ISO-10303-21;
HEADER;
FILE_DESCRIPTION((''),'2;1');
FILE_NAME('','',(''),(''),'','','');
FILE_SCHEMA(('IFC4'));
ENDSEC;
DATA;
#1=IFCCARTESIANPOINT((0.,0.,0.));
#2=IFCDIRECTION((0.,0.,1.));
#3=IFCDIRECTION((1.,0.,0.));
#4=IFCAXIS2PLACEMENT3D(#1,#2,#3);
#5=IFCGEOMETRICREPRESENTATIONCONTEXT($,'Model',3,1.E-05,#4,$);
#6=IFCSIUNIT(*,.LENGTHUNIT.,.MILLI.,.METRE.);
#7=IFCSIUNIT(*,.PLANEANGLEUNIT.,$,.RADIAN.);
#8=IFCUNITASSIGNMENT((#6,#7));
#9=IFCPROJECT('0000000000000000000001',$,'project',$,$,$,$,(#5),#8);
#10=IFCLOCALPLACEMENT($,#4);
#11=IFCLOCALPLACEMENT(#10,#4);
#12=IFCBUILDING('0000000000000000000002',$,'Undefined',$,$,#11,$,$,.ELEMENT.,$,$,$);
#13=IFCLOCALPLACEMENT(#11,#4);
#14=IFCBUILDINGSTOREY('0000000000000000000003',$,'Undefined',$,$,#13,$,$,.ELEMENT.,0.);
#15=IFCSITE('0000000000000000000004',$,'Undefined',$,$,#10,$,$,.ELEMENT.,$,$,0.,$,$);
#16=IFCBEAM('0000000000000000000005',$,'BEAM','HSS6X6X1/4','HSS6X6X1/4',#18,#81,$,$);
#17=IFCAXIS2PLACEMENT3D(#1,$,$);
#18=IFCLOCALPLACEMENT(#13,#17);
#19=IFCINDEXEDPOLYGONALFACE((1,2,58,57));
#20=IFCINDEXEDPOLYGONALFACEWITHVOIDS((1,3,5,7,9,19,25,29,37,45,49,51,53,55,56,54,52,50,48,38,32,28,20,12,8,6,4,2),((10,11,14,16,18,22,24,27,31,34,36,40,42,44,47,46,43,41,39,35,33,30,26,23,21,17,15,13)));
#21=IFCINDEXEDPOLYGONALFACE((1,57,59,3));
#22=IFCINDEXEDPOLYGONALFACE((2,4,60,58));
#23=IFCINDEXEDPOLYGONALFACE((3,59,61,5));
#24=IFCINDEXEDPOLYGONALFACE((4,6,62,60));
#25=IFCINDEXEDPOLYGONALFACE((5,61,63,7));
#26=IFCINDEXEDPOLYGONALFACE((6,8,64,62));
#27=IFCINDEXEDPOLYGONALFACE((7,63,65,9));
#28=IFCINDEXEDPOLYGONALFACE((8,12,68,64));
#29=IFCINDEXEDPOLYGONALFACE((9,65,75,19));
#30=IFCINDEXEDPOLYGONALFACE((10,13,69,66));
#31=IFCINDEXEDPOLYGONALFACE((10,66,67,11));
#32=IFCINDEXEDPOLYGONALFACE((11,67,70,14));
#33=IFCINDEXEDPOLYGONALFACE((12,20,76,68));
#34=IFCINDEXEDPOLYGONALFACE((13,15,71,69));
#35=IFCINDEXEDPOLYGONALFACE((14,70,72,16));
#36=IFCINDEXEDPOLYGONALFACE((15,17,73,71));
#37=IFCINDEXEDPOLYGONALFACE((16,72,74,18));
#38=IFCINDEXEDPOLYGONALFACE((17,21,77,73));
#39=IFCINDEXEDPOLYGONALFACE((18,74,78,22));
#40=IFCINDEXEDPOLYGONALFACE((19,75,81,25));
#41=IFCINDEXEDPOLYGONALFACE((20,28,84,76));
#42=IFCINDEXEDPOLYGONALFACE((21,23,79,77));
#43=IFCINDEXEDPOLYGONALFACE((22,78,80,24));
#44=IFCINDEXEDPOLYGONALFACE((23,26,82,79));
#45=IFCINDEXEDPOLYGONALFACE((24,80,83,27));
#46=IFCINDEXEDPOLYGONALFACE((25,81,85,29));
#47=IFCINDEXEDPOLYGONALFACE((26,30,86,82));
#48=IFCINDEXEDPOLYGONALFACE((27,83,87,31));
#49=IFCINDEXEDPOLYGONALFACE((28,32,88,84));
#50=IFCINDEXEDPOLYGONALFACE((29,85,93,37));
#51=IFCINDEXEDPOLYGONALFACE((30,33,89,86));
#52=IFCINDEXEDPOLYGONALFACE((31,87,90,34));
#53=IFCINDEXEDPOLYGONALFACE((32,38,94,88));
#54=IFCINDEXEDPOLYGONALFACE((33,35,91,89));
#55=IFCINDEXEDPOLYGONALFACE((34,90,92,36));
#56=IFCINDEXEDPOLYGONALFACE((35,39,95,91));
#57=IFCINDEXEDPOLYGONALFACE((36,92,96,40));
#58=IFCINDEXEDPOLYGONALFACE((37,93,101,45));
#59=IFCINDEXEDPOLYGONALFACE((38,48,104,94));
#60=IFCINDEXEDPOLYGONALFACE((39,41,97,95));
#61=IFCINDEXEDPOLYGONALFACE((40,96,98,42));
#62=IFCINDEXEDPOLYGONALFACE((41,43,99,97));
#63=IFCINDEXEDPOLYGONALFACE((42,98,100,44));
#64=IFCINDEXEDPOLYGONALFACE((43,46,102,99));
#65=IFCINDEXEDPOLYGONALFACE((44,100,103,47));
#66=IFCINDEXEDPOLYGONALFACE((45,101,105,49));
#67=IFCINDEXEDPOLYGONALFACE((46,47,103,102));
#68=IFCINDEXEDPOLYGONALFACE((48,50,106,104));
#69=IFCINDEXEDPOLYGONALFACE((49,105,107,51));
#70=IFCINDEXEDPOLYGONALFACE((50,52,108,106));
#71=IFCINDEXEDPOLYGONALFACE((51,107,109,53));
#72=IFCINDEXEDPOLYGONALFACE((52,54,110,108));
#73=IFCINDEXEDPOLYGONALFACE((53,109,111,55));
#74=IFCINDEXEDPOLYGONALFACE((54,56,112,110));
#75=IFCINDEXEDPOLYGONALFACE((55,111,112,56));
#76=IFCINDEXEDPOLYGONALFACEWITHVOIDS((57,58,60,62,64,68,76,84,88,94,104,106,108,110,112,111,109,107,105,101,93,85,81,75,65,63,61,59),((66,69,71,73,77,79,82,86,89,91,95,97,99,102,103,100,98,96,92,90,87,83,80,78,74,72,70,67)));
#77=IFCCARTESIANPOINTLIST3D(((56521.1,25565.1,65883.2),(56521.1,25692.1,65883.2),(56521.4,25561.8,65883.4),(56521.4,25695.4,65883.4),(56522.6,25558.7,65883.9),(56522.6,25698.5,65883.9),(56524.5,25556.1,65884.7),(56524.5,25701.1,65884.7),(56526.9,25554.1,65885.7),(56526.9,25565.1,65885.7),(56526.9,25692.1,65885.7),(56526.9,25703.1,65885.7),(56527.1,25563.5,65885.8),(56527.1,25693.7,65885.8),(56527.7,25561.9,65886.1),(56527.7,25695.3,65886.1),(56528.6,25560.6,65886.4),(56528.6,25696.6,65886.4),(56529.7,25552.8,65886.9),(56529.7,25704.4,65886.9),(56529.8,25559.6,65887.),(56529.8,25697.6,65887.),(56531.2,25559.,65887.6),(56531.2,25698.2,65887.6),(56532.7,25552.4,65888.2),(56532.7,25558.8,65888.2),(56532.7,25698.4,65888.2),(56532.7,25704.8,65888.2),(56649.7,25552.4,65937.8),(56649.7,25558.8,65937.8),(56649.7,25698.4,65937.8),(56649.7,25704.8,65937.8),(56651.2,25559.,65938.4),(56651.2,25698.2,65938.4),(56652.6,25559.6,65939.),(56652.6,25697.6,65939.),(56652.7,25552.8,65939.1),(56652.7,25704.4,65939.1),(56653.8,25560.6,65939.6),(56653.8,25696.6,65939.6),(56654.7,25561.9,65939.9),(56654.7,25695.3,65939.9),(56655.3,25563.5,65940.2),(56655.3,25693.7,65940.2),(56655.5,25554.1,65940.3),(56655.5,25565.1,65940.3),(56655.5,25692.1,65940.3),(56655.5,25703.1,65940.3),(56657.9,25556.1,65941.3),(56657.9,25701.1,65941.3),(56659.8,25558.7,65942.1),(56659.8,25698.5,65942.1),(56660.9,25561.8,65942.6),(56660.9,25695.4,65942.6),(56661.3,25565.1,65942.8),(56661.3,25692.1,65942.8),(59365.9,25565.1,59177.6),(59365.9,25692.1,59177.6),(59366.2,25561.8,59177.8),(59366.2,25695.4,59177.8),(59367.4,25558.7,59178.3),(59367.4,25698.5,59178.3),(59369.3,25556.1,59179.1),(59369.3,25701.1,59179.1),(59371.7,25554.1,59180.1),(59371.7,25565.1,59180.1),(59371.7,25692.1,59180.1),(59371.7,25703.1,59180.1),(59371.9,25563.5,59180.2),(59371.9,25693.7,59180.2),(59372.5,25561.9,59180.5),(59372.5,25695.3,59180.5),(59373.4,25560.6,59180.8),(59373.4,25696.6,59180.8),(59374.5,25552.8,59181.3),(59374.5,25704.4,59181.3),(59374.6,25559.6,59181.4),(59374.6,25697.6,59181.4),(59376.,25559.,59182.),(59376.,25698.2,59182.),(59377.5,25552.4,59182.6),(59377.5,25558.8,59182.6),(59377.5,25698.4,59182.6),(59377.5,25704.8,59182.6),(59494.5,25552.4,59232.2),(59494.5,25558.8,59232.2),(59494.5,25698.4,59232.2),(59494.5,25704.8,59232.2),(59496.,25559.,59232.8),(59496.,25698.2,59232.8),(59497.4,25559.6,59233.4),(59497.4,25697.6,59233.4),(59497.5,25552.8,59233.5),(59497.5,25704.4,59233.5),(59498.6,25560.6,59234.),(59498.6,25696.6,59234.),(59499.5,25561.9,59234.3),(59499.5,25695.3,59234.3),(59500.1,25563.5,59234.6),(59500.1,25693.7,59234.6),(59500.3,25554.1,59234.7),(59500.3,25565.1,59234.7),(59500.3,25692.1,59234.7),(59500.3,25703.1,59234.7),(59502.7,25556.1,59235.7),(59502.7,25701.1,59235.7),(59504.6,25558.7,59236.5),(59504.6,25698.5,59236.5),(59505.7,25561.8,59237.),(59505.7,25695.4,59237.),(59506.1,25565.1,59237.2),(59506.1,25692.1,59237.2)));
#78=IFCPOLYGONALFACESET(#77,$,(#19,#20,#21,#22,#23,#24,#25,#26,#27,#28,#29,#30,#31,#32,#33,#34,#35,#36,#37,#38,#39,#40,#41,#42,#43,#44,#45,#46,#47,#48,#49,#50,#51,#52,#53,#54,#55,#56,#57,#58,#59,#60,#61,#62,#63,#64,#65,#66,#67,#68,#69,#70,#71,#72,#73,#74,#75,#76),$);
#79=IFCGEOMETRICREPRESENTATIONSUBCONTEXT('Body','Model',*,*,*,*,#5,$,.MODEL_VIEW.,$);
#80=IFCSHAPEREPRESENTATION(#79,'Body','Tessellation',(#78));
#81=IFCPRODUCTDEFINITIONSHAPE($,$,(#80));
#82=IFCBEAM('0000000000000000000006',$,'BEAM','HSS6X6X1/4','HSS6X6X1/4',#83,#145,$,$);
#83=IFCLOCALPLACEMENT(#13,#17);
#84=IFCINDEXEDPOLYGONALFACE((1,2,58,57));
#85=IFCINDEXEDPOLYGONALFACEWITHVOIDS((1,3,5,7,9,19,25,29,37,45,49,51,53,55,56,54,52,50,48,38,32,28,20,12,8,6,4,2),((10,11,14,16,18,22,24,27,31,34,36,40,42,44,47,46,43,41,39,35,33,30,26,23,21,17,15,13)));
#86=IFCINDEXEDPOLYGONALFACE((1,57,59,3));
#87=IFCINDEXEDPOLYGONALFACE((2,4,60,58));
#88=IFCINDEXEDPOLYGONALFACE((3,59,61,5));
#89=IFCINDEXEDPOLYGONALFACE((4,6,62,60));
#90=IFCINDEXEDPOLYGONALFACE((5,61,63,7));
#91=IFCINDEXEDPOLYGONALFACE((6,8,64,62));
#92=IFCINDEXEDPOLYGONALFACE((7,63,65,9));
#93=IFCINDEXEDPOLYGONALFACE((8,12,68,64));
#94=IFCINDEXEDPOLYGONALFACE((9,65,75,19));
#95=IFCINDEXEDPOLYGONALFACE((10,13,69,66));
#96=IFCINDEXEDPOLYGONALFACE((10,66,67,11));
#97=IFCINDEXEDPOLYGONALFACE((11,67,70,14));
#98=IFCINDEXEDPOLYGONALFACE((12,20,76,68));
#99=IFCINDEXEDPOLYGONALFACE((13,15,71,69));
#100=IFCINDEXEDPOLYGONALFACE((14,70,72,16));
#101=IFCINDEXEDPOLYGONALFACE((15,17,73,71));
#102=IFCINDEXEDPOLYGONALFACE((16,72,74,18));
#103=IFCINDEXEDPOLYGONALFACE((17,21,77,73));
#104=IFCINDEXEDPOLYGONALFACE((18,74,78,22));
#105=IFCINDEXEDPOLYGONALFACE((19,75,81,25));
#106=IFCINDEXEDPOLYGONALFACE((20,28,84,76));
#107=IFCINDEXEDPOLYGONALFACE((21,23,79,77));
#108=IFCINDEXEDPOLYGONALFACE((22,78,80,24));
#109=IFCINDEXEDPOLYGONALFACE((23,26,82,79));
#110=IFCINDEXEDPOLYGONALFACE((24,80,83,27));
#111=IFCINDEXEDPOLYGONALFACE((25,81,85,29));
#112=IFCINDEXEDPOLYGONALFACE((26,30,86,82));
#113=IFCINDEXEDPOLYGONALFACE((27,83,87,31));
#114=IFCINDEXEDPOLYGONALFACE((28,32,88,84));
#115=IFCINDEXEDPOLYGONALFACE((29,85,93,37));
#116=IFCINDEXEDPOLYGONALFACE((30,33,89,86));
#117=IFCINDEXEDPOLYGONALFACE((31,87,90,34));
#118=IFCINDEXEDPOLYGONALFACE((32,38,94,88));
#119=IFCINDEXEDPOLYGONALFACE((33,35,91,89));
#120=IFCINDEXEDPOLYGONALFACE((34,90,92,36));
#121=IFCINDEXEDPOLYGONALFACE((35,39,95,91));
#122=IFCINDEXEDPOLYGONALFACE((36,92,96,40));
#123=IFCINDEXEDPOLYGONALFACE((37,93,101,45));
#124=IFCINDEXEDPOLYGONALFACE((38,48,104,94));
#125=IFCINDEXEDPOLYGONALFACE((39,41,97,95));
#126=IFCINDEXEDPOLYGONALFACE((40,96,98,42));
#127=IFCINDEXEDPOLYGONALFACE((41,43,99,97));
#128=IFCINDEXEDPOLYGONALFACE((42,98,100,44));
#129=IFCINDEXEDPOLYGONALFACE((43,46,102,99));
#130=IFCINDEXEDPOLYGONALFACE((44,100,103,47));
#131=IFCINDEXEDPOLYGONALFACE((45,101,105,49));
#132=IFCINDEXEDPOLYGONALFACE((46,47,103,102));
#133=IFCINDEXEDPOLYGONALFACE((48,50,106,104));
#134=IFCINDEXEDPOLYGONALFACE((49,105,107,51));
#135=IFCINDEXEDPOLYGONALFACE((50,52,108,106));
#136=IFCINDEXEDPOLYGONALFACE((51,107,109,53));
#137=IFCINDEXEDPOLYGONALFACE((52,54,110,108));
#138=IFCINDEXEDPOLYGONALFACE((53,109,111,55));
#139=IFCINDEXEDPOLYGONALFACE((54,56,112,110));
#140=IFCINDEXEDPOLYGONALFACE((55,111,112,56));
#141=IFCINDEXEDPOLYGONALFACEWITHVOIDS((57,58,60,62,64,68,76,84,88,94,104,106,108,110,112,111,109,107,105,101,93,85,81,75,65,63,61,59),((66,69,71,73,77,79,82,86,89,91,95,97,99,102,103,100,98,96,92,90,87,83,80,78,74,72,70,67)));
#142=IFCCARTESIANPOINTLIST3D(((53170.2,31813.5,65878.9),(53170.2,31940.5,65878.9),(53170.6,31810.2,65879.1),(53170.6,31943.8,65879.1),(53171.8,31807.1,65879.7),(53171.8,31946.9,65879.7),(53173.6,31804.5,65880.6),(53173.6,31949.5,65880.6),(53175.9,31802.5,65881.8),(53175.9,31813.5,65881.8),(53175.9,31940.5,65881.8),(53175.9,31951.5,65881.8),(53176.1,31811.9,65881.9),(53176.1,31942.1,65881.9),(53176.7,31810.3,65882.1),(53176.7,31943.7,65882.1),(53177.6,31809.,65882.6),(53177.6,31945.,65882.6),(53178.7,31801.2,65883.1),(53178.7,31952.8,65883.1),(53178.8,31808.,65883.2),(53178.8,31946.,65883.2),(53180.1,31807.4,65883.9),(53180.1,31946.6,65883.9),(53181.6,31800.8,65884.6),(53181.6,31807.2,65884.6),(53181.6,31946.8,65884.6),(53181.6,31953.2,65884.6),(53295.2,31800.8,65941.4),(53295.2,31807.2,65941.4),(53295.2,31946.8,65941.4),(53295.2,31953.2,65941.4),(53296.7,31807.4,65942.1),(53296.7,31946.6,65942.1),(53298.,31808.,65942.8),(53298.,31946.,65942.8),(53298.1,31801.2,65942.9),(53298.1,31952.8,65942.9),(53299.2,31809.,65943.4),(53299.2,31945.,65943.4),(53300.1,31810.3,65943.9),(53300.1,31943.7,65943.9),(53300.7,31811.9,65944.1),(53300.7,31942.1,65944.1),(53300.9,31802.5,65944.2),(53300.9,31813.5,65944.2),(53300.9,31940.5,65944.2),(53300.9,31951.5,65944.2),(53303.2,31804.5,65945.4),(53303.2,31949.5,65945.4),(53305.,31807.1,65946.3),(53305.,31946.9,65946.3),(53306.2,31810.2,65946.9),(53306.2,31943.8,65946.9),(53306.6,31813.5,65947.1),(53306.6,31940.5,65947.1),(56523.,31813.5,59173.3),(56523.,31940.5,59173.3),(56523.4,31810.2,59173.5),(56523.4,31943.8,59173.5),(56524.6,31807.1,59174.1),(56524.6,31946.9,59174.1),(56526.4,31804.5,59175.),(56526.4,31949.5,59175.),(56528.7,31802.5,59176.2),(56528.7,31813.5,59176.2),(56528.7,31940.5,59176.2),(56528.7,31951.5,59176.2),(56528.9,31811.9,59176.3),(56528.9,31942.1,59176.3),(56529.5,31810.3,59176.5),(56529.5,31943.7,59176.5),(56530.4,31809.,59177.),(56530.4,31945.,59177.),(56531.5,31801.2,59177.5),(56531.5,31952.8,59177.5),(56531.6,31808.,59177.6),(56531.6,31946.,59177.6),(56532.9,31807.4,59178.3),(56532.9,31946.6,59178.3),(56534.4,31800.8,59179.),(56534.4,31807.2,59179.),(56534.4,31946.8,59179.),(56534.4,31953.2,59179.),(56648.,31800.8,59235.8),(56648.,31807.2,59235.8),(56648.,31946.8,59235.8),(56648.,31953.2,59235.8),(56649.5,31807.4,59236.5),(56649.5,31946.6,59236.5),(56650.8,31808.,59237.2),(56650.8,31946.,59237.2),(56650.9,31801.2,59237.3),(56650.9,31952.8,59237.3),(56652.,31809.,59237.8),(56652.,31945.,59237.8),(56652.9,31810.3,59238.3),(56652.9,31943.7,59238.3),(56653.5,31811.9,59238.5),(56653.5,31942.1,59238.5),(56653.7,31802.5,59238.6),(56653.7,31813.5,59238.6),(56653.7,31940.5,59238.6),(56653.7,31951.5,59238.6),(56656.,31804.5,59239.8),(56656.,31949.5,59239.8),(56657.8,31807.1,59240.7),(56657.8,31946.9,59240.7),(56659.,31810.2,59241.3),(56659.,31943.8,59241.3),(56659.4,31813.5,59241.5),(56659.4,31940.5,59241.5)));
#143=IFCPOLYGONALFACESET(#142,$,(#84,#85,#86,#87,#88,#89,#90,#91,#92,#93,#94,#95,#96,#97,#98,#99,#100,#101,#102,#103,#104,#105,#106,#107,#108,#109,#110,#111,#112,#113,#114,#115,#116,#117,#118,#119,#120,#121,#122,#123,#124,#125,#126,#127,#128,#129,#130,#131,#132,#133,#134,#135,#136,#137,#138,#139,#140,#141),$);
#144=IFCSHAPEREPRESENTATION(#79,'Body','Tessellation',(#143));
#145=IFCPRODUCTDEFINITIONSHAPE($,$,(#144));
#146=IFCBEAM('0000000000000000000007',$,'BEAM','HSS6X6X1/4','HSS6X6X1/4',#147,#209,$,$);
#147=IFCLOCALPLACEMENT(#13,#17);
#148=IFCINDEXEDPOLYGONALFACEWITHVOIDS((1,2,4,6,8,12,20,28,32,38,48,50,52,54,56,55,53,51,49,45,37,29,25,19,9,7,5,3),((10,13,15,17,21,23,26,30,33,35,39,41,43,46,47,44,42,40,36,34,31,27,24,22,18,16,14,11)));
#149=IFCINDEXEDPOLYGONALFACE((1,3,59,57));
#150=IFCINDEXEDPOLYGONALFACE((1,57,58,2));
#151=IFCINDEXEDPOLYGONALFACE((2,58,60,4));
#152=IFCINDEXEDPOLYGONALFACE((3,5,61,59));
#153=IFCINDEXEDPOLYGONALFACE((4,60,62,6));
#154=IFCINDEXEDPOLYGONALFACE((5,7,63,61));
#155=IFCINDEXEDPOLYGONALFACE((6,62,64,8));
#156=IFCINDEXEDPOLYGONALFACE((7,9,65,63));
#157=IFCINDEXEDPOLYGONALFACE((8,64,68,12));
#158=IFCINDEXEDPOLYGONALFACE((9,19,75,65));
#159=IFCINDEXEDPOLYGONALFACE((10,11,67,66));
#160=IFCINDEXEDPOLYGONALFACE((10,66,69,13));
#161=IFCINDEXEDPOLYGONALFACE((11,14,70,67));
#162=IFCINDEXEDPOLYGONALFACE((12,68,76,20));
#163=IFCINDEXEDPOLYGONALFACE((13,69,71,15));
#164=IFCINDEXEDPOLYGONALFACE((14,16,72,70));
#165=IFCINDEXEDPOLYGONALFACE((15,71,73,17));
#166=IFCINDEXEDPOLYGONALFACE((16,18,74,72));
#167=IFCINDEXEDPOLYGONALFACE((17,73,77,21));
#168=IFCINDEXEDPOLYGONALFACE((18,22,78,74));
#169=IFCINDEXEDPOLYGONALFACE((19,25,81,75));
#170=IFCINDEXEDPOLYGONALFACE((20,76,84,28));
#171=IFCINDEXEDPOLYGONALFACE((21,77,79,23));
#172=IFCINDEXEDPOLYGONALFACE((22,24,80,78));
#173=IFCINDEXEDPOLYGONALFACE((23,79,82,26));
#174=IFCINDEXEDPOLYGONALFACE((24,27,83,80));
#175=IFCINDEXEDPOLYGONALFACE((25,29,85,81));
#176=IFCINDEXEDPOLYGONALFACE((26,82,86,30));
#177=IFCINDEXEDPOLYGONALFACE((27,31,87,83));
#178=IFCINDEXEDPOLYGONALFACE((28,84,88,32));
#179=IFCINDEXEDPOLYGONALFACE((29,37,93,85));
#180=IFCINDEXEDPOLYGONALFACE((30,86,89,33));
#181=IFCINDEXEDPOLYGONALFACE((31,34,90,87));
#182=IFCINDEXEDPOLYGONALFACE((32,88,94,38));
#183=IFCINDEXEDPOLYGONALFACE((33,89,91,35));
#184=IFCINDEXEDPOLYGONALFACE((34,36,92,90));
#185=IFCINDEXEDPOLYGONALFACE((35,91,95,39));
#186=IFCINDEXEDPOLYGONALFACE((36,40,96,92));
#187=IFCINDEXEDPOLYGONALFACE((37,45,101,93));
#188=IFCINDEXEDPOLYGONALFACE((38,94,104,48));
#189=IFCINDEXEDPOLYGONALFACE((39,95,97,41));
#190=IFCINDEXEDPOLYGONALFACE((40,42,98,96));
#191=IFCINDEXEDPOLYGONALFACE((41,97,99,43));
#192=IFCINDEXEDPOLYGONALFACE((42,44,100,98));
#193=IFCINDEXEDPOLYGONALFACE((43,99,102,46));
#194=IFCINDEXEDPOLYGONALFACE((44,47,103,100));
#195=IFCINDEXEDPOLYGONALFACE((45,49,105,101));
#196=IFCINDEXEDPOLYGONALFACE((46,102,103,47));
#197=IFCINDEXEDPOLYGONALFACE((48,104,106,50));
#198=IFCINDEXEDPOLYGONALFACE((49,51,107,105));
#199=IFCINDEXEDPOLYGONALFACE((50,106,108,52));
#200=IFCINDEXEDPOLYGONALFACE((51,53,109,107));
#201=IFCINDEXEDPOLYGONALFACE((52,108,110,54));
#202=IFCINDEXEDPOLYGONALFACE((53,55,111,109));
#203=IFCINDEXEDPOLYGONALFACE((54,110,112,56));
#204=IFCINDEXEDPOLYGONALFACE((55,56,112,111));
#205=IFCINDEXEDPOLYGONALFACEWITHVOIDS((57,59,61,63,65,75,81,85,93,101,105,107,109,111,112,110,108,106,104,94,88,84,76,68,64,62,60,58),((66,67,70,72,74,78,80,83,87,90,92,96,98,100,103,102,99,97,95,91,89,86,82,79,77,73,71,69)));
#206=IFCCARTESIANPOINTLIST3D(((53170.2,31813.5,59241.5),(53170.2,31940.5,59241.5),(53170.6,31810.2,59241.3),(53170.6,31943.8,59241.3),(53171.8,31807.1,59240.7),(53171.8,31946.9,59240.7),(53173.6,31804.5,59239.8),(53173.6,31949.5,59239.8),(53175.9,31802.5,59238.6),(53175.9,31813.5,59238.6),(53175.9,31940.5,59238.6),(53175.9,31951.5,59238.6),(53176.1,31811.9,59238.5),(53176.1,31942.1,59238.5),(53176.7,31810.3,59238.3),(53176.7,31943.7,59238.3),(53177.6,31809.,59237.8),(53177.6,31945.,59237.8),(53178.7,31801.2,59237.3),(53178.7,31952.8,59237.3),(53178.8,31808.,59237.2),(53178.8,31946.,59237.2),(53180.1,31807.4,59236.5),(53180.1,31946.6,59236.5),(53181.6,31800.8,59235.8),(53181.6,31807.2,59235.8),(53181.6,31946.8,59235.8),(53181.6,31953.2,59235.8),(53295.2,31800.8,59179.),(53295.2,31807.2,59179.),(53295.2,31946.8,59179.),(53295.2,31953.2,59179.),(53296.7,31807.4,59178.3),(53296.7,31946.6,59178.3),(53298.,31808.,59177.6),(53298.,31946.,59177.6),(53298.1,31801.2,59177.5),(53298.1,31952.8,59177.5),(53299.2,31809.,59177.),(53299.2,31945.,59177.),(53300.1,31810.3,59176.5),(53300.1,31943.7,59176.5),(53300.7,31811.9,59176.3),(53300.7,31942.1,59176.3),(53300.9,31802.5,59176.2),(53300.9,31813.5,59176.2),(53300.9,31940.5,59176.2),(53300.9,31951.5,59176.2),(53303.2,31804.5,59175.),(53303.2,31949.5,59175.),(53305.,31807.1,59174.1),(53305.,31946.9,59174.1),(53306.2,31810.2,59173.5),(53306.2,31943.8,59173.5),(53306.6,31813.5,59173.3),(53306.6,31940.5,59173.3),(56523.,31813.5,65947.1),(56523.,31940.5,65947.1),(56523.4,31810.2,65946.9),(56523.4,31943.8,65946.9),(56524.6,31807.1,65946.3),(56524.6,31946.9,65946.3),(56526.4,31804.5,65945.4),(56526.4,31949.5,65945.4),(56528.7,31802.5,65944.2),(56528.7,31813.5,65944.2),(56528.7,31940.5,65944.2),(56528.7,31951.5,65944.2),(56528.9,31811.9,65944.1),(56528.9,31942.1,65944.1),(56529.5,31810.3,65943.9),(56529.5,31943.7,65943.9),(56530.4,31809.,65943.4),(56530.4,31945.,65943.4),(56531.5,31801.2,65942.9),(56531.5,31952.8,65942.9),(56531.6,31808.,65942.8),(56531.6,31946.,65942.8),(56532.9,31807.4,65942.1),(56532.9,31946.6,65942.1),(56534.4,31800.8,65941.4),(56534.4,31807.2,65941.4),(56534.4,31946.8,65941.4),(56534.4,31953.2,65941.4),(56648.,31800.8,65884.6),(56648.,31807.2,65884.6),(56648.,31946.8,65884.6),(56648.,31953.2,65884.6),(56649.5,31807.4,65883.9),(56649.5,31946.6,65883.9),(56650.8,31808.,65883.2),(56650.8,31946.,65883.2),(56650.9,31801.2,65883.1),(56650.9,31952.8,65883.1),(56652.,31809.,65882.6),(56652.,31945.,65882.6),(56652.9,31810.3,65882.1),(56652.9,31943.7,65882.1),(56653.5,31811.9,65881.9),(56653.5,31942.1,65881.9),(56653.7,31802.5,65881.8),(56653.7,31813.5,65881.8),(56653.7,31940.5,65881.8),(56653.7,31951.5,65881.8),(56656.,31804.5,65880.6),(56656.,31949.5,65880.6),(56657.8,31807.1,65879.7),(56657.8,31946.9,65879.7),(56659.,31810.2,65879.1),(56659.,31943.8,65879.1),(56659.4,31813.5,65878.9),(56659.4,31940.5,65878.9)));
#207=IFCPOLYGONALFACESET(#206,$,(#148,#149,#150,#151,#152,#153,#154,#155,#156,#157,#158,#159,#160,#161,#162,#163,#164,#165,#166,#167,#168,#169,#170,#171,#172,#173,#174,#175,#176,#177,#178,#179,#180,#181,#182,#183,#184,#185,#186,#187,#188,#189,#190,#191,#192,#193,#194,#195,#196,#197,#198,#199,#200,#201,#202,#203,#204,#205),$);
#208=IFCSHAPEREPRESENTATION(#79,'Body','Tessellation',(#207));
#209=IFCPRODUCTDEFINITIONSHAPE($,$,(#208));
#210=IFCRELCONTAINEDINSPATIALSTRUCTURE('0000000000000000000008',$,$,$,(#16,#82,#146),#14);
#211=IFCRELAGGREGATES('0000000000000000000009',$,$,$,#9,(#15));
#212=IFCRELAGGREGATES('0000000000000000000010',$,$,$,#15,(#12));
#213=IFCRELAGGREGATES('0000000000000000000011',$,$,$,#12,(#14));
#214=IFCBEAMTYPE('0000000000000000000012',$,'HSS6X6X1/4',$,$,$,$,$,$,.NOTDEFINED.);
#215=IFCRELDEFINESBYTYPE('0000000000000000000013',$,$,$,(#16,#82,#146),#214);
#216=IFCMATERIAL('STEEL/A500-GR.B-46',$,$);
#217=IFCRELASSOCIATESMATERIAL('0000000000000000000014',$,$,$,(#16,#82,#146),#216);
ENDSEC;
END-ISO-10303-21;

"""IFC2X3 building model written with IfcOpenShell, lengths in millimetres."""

from ifc_helpers import new_model, si_unit, frame, origin_with_axes, origin_2d_with_axis, place, context, subcontext, project, spatial, hollow_rectangle, extrude, material, type_object, element, save


model = new_model("IFC2X3")

# Units and contexts
model_context = context("Model", 3, precision=1e-05, world=origin_with_axes())
body_context = subcontext(model_context, "Body", "Model", "MODEL_VIEW")
ifc_project = project(units=[si_unit("LENGTHUNIT", "METRE", prefix="MILLI"), si_unit("PLANEANGLEUNIT", "RADIAN")], contexts=[model_context])

# Site, building, storey
site_placement = place(None, origin_with_axes())
site = spatial("IfcSite", under=ifc_project, at=site_placement, Name="Undefined", CompositionType="ELEMENT", RefElevation=0.0)
building_placement = place(site_placement, origin_with_axes())
building = spatial("IfcBuilding", under=site, at=building_placement, Name="Undefined", CompositionType="ELEMENT")
storey_placement = place(building_placement, origin_with_axes())
storey = spatial("IfcBuildingStorey", under=building, at=storey_placement, Name="Undefined", CompositionType="ELEMENT", Elevation=0.0)

# Beams
ifc_material_1 = material(Name="STEEL/A500-GR.B-46")
beam_type_1 = type_object("IfcBeamType", Name="HSS6X6X1/4", PredefinedType="NOTDEFINED")
beam_1_placement = place(storey_placement, frame((59436.0, 25628.6, 59207.4), z_axis=(0.920582, 0.0, 0.39055), x_axis=(-0.39055, 0.0, 0.920582)))
element("IfcBeam", 1, at=beam_1_placement, inside=storey, type_object=beam_type_1, material=ifc_material_1, Name="BEAM", Description="HSS6X6X1/4", ObjectType="HSS6X6X1/4", context=body_context, shape_type="SweptSolid", body=[
    extrude(hollow_rectangle(XDim=152.4, YDim=152.4, WallThickness=6.3, InnerFilletRadius=6.3, OuterFilletRadius=12.7, at=origin_2d_with_axis()), frame((7284.1, 0.0, 0.0), z_axis=(-1.0, 0.0, 0.0), x_axis=(0.0, -1.0, 0.0)), (0.0, 0.0, 1.0), 7284.1),
])
for number, where, z_axis, x_axis, name in (
    (2, (56591.2, 31877.0, 59207.4), (0.894427, 0.0, 0.447214), (-0.447214, 0.0, 0.894427), "BEAM"),
    (3, (53238.4, 31877.0, 59207.4), (-0.894427, 0.0, 0.447214), (0.447214, 0.0, 0.894427), "BEAM"),
):
    element("IfcBeam", number, at=place(storey_placement, frame(where, z_axis=z_axis, x_axis=x_axis)), inside=storey, type_object=beam_type_1, material=ifc_material_1, Name=name, Description="HSS6X6X1/4", ObjectType="HSS6X6X1/4", context=body_context, shape_type="SweptSolid", body=[
        extrude(hollow_rectangle(XDim=152.4, YDim=152.4, WallThickness=6.3, InnerFilletRadius=6.3, OuterFilletRadius=12.7, at=origin_2d_with_axis()), frame((7497.1, 0.0, 0.0), z_axis=(-1.0, 0.0, 0.0), x_axis=(0.0, -1.0, 0.0)), (0.0, 0.0, 1.0), 7497.1),
    ])

save(model, "model.ifc")
